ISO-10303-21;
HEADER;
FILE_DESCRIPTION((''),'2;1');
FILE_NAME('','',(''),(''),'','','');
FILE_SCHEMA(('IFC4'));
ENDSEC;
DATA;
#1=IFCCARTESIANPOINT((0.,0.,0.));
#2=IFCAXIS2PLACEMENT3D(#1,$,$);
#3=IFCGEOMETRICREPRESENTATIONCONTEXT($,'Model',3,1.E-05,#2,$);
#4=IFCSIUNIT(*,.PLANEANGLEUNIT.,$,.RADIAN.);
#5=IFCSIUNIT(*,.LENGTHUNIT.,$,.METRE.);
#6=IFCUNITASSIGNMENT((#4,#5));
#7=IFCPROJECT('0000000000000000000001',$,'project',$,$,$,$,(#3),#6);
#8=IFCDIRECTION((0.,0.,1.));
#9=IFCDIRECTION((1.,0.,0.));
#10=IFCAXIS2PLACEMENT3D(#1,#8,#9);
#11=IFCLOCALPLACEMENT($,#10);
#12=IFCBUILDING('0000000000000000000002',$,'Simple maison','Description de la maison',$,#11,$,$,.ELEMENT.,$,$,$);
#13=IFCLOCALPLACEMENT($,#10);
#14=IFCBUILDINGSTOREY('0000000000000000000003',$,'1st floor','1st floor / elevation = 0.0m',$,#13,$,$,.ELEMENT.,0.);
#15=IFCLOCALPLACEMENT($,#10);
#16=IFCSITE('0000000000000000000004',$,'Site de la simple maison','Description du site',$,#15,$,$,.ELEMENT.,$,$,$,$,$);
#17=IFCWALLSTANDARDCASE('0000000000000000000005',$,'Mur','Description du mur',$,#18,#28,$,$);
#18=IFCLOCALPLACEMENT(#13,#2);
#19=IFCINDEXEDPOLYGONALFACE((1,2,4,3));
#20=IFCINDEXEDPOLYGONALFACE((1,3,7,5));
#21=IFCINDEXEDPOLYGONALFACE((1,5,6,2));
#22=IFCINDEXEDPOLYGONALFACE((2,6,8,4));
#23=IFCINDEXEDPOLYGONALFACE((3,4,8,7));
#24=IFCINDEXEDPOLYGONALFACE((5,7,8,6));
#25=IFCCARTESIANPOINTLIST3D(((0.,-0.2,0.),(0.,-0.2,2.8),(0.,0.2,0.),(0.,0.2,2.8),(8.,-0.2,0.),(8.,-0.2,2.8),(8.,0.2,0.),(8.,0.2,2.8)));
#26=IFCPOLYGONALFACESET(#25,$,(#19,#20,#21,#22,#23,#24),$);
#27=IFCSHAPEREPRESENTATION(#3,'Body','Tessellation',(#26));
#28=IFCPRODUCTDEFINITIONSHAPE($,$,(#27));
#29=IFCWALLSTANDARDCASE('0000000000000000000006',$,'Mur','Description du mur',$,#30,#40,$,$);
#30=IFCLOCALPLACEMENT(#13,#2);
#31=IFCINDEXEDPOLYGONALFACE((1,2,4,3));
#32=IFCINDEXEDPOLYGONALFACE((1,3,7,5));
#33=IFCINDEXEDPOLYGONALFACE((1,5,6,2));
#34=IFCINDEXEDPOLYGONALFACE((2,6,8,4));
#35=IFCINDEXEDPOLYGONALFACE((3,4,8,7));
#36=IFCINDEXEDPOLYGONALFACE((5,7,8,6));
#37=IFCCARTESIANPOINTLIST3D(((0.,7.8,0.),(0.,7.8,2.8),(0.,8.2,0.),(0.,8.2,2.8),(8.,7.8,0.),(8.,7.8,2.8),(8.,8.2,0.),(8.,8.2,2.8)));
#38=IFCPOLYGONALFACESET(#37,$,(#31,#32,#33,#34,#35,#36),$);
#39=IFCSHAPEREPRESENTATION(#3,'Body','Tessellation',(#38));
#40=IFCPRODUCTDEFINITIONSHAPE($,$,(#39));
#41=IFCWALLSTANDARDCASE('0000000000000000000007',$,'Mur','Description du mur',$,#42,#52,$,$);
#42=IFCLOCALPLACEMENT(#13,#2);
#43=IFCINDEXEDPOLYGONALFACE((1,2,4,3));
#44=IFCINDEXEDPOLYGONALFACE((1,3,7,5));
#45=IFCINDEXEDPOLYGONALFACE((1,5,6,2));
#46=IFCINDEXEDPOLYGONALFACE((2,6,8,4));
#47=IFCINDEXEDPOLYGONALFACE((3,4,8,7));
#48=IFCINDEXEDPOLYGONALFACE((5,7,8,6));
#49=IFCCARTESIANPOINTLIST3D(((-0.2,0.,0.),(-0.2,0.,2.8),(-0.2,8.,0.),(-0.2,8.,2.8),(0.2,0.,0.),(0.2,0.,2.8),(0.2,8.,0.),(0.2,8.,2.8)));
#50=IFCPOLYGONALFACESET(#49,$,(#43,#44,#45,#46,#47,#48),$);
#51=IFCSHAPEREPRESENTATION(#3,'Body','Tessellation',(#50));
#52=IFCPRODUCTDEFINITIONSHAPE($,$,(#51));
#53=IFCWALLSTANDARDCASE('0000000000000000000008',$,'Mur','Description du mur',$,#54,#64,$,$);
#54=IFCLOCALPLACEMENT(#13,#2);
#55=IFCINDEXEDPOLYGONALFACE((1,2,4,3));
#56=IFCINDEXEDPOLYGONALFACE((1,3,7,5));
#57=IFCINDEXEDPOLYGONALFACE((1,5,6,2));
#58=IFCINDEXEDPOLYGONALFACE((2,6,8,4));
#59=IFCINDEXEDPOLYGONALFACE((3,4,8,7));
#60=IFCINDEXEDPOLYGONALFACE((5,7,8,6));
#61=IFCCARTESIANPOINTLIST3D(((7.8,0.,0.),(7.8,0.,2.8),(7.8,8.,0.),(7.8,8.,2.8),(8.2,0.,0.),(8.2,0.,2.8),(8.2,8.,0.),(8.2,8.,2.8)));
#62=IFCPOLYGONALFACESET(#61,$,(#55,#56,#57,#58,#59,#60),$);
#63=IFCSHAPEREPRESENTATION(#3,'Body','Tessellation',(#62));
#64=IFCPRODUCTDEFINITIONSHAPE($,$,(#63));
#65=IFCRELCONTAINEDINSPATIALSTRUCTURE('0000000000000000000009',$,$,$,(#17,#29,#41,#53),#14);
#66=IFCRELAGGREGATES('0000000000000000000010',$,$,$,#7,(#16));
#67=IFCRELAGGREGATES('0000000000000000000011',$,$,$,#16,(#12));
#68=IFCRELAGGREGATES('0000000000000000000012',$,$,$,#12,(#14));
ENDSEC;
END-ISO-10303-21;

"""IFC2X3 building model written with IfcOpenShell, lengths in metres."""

from ifc_helpers import new_model, si_unit, frame, origin, origin_with_axes, place, context, project, spatial, polyline, outline, extrude, element, save


model = new_model("IFC2X3")

# Units and contexts
model_context = context("Model", 3, precision=1e-05, world=origin())
ifc_project = project(units=[si_unit("PLANEANGLEUNIT", "RADIAN"), si_unit("LENGTHUNIT", "METRE")], contexts=[model_context])

# Site, building, storey
site_placement = place(None, origin_with_axes())
site = spatial("IfcSite", under=ifc_project, at=site_placement, Name="Site de la simple maison", Description="Description du site", CompositionType="ELEMENT")
building_placement = place(None, origin_with_axes())
building = spatial("IfcBuilding", under=site, at=building_placement, Name="Simple maison", Description="Description de la maison", CompositionType="ELEMENT")
storey_placement = place(None, origin_with_axes())
storey = spatial("IfcBuildingStorey", under=building, at=storey_placement, Name="1st floor", Description="1st floor / elevation = 0.0m", CompositionType="ELEMENT", Elevation=0.0)

# Walls
for number, where, z_axis, x_axis, name in (
    (1, (0.0, 0.0, 0.0), (0.0, 0.0, 1.0), (1.0, 0.0, 0.0), "Mur"),
    (2, (0.0, 8.0, 0.0), (0.0, 0.0, 1.0), (1.0, 0.0, 0.0), "Mur"),
    (3, (0.0, 0.0, 0.0), (0.0, 0.0, 1.0), (0.0, 1.0, 0.0), "Mur"),
    (4, (8.0, 0.0, 0.0), (0.0, 0.0, 1.0), (0.0, 1.0, 0.0), "Mur"),
):
    element("IfcWallStandardCase", number, at=place(storey_placement, frame(where, z_axis=z_axis, x_axis=x_axis)), inside=storey, Name=name, Description="Description du mur", context=model_context, shape_type="SweptSolid", body=[
        extrude(outline(polyline([(0.0, 0.2), (8.0, 0.2), (8.0, -0.2), (0.0, -0.2)])), origin_with_axes(), (0.0, 0.0, 1.0), 2.8),
    ])

save(model, "model.ifc")
